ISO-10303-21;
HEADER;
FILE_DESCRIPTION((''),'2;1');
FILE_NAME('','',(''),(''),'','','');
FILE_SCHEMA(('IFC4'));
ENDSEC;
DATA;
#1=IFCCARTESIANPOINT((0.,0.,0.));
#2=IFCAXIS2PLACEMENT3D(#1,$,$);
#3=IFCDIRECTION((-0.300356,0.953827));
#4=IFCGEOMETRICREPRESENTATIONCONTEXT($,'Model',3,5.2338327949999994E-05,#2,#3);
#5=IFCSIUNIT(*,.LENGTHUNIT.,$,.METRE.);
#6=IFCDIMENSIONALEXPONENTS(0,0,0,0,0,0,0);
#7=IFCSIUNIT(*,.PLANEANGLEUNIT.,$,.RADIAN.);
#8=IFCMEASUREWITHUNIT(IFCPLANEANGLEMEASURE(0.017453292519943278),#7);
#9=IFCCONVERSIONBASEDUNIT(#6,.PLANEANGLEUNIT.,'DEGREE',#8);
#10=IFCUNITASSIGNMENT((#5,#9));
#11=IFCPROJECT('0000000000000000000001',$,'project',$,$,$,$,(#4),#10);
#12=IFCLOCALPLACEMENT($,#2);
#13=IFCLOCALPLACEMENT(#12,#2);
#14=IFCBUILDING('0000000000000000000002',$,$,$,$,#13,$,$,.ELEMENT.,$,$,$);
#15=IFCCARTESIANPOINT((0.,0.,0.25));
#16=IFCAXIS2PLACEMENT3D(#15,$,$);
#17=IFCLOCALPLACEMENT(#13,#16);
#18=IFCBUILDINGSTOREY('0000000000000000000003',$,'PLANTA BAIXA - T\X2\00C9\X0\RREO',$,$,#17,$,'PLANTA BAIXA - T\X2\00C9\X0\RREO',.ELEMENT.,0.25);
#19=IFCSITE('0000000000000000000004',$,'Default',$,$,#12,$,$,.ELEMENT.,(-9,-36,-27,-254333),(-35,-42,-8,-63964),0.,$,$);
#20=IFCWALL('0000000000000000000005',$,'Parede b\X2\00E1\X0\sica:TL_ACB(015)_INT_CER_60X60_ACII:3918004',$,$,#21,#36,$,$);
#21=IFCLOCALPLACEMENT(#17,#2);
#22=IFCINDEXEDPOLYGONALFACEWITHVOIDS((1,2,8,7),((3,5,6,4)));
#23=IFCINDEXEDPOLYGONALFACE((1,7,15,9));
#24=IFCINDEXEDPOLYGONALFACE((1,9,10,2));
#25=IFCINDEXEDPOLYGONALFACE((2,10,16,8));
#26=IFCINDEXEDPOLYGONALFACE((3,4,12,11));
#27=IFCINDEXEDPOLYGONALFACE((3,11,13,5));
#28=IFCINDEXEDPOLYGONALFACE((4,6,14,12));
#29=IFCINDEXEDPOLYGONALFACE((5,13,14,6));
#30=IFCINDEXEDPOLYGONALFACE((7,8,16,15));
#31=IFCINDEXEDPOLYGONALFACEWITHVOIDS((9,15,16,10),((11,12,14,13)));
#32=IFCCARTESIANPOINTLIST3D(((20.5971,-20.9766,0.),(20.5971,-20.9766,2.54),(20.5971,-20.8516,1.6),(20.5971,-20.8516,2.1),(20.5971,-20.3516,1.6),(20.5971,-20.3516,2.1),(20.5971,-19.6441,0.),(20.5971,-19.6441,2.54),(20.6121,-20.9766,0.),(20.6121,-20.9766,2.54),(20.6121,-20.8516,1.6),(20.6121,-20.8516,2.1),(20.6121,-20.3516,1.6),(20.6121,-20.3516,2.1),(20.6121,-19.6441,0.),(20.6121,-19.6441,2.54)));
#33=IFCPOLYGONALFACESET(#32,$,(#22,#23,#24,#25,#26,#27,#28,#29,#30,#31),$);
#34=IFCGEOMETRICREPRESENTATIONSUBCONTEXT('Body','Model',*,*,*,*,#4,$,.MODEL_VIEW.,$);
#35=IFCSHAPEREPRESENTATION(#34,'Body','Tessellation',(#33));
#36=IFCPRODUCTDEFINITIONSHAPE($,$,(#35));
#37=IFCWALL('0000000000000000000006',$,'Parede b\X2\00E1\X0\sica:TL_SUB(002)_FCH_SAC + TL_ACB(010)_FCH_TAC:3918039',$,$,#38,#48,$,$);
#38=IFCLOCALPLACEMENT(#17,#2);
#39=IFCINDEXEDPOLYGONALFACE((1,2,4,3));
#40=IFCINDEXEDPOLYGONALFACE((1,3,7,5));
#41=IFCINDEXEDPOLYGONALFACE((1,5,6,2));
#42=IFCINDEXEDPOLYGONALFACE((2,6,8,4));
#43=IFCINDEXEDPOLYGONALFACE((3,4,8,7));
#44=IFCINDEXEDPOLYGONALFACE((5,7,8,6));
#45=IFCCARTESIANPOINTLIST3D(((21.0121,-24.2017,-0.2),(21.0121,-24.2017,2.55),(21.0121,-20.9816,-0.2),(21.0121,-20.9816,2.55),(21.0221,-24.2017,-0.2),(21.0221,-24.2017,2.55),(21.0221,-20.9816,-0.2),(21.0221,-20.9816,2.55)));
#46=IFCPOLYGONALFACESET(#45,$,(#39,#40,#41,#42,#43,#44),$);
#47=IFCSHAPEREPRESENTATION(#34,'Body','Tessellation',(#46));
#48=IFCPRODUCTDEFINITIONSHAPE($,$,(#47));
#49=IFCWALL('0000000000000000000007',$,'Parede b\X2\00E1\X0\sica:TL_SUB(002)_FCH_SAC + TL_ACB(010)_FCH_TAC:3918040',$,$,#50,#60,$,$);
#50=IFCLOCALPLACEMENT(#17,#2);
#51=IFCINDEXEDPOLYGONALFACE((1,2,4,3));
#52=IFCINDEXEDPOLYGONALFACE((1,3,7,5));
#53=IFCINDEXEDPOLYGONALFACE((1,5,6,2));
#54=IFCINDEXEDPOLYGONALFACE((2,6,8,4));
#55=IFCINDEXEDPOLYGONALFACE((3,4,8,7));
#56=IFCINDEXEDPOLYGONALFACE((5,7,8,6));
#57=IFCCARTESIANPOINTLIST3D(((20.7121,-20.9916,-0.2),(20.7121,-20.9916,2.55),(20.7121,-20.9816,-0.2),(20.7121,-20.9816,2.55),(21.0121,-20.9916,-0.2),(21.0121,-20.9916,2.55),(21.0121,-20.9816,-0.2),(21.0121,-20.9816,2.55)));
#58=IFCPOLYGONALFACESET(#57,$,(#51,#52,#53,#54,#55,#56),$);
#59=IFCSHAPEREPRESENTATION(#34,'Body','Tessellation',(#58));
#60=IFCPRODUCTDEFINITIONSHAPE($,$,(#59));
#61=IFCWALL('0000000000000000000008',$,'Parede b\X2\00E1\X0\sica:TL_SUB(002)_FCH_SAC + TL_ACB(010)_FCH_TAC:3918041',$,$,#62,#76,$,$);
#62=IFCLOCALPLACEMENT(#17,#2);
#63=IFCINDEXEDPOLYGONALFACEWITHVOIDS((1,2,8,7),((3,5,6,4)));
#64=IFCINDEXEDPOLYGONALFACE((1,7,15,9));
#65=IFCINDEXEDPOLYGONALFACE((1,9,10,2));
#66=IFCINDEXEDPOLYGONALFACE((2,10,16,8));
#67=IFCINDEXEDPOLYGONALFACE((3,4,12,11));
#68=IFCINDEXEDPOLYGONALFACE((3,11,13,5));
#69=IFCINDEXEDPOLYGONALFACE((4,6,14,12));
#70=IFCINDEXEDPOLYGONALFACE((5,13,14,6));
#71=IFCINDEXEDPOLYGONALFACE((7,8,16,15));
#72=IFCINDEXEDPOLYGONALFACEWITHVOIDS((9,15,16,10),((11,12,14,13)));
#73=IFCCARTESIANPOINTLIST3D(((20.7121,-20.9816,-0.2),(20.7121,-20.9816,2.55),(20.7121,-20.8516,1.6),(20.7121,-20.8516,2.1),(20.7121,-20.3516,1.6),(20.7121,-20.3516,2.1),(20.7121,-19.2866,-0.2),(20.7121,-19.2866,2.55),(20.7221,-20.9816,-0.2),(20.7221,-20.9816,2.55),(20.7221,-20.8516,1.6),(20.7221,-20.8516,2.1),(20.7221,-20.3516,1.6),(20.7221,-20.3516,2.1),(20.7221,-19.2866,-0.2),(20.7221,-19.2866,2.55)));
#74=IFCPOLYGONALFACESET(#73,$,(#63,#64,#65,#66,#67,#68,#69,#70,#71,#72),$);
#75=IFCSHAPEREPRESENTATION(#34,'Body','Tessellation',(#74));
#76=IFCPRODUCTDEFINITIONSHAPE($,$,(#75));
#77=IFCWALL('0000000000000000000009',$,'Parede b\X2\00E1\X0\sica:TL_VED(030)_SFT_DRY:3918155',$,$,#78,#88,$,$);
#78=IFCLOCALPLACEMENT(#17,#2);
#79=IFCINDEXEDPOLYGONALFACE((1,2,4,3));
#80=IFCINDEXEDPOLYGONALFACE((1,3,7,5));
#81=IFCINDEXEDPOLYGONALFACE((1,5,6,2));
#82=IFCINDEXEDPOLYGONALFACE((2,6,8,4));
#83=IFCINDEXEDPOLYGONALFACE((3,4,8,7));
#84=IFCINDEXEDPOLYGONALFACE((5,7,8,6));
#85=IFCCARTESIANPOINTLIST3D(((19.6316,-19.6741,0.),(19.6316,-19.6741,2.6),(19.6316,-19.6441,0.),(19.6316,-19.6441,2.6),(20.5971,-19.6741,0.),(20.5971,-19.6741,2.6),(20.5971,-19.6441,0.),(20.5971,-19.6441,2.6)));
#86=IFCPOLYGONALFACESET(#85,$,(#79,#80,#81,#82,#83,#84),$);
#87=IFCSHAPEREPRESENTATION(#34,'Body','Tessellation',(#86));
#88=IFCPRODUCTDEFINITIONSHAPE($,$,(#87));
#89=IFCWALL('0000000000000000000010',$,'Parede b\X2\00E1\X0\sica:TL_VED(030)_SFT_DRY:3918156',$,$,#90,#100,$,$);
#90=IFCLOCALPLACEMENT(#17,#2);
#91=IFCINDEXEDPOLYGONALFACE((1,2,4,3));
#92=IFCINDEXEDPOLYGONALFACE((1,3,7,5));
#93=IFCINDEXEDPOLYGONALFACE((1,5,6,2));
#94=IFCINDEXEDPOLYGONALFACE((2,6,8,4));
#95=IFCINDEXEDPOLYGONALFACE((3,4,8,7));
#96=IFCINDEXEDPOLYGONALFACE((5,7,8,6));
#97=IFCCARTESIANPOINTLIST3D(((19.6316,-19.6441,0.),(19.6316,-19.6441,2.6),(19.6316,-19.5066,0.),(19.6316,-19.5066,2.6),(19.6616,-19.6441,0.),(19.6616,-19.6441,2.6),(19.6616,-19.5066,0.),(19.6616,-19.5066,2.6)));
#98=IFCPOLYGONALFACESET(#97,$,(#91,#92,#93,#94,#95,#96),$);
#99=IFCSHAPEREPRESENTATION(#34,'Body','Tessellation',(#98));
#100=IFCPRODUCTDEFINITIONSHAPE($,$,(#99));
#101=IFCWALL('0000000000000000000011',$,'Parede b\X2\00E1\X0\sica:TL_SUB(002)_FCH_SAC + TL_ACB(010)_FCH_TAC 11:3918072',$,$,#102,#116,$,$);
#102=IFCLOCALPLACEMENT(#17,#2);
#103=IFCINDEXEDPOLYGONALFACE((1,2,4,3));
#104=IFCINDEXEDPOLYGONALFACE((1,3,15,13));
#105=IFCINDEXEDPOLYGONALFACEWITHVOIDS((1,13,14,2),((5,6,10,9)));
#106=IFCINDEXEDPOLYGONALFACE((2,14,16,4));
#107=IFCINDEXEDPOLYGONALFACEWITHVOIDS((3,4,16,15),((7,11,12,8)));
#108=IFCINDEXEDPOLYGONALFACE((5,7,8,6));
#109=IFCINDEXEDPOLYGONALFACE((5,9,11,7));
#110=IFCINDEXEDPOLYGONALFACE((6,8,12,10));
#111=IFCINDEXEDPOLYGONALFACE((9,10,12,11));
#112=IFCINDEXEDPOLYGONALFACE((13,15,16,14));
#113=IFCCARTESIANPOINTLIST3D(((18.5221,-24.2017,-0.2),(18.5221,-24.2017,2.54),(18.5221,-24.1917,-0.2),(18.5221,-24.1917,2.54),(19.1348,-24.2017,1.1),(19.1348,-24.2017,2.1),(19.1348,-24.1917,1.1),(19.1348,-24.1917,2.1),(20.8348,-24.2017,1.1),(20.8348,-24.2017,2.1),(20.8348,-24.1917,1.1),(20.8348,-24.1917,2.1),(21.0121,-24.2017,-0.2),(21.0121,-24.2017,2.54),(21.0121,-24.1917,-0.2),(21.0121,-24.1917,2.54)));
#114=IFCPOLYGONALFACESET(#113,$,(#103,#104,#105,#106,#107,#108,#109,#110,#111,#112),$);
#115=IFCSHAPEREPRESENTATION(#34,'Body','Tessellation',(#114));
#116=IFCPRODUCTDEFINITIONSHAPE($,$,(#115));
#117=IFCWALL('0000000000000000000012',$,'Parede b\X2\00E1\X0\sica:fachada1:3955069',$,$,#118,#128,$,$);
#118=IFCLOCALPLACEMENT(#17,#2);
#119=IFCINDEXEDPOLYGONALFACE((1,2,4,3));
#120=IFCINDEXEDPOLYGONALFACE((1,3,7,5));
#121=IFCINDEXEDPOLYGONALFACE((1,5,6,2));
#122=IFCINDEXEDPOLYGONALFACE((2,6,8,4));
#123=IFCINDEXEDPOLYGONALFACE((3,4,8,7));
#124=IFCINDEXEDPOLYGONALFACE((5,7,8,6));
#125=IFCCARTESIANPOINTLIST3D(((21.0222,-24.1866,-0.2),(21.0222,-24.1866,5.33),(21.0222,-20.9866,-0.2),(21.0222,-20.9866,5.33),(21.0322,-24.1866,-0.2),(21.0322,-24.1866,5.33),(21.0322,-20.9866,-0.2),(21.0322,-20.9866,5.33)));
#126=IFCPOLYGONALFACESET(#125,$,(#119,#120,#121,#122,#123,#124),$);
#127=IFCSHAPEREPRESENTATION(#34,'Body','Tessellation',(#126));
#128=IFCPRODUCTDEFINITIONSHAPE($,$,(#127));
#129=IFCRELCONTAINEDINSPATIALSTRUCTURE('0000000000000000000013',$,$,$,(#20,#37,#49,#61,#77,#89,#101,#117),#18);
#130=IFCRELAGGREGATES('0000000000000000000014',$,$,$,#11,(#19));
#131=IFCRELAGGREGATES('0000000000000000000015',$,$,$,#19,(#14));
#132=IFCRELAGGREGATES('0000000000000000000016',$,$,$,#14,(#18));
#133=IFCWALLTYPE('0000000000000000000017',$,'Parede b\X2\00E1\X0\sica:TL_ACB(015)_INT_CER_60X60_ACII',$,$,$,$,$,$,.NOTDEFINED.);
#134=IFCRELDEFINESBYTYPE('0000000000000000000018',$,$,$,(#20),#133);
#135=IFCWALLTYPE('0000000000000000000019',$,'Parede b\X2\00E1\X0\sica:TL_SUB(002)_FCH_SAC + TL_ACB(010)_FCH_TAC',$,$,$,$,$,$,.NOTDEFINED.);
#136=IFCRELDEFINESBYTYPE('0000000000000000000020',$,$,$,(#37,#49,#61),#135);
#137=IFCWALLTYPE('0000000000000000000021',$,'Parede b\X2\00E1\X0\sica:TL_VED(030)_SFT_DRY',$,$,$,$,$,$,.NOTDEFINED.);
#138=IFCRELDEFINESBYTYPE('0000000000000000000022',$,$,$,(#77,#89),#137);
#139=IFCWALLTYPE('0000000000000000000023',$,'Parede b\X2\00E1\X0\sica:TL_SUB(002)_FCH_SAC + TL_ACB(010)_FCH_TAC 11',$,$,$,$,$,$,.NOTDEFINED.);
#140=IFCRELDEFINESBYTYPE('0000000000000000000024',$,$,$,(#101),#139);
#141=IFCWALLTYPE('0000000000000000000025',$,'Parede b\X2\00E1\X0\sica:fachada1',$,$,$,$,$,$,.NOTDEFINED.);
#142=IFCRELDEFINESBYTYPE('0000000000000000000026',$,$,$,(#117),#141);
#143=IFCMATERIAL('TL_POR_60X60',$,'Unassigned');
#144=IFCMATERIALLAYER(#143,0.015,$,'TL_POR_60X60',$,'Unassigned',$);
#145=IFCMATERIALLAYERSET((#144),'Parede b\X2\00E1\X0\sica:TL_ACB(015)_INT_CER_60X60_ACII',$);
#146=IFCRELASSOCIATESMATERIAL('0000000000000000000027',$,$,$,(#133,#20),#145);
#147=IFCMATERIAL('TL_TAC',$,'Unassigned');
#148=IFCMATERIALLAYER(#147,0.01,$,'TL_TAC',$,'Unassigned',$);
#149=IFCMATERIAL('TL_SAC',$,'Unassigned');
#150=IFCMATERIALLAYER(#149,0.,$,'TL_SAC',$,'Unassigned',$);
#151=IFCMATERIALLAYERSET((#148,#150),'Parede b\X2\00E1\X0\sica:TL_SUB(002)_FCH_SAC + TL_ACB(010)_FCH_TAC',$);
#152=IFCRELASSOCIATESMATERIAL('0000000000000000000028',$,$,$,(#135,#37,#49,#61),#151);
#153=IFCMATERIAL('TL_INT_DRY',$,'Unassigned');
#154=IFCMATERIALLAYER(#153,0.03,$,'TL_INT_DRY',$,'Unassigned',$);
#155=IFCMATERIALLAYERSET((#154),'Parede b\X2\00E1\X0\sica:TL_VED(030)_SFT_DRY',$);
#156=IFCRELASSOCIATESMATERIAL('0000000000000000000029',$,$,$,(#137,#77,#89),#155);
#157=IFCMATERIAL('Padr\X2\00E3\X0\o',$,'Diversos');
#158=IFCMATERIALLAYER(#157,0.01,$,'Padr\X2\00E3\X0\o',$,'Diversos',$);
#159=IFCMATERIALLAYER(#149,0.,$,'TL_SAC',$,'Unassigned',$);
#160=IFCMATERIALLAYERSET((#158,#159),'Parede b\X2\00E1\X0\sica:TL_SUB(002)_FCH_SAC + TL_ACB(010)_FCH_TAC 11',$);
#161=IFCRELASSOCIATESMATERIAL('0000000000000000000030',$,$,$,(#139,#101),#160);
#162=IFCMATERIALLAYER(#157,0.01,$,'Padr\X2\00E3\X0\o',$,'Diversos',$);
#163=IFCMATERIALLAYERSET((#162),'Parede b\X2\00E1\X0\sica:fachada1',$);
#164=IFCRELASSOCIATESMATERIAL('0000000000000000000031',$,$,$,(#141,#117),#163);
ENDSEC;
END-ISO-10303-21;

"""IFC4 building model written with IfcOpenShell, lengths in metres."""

from ifc_helpers import new_model, entity, si_unit, converted_unit, direction, frame, frame_2d, origin, place, context, subcontext, project, spatial, rectangle, extrude, material, layer, layer_set, layer_usage, type_object, element, save


model = new_model("IFC4")

# Units and contexts
model_context = context("Model", 3, precision=5.2338327949999994e-05, world=origin(), true_north=direction((-0.300356, 0.953827)))
body_context = subcontext(model_context, "Body", "Model", "MODEL_VIEW")
ifc_project = project(units=[si_unit("LENGTHUNIT", "METRE"), converted_unit("PLANEANGLEUNIT", "DEGREE", entity("IfcPlaneAngleMeasure", 0.017453292519943278), si_unit("PLANEANGLEUNIT", "RADIAN"), dimensions=[0, 0, 0, 0, 0, 0, 0])], contexts=[model_context])

# Site, building, storey
site_placement = place(None, origin())
site = spatial("IfcSite", under=ifc_project, at=site_placement, Name="Default", CompositionType="ELEMENT", RefLatitude=(-9, -36, -27, -254333), RefLongitude=(-35, -42, -8, -63964), RefElevation=0.0)
building_placement = place(site_placement, origin())
building = spatial("IfcBuilding", under=site, at=building_placement, CompositionType="ELEMENT")
storey_placement = place(building_placement, frame((0.0, 0.0, 0.25)))
storey = spatial("IfcBuildingStorey", under=building, at=storey_placement, Name="PLANTA BAIXA - TÉRREO", LongName="PLANTA BAIXA - TÉRREO", CompositionType="ELEMENT", Elevation=0.25)

# Shared definitions
ifc_material_1 = material(Name="TL_SAC", Category="Unassigned")

# Shared definitions
ifc_material_2 = material(Name="TL_POR_60X60", Category="Unassigned")
ifc_layer_1 = layer(ifc_material_2, 0.015, Name="TL_POR_60X60", Category="Unassigned")
ifc_layer_set_1 = layer_set([ifc_layer_1], Name="Parede básica:TL_ACB(015)_INT_CER_60X60_ACII")
wall_type_1 = type_object("IfcWallType", Name="Parede básica:TL_ACB(015)_INT_CER_60X60_ACII", PredefinedType="NOTDEFINED", material=ifc_layer_set_1)

# Wall, opening
ifc_layer_usage_1 = layer_usage(ifc_layer_set_1, "AXIS2", "NEGATIVE", 0.0075)
wall_1_placement = place(storey_placement, frame((20.6046, -20.9766, 0.0), z_axis=(0.0, 0.0, 1.0), x_axis=(0.0, 1.0, 0.0)))
wall_1 = element("IfcWall", 1, at=wall_1_placement, inside=storey, type_object=wall_type_1, material=ifc_layer_usage_1, Name="Parede básica:TL_ACB(015)_INT_CER_60X60_ACII:3918004", context=body_context, shape_type="SweptSolid", body=[
    extrude(rectangle(XDim=1.3325, YDim=0.015, at=frame_2d((0.6662, 0.0), x_axis=(-1.0, 0.0))), origin(), (0.0, 0.0, 1.0), 2.54),
])
opening_1_placement = place(wall_1_placement, frame((20.9766, 20.6046, 1.6)))
element("IfcOpeningElement", 2, at=opening_1_placement, cuts=wall_1, PredefinedType="OPENING", context=body_context, shape_type="SweptSolid", body=[
    extrude(rectangle(XDim=0.5, YDim=0.5, at=frame_2d((0.0, 0.0), x_axis=(1.0, 0.0))), frame((-20.6016, -22.2361, 0.25), z_axis=(0.0, 1.0, 0.0), x_axis=(0.0, 0.0, 1.0)), (0.0, 0.0, 1.0), 3.048),
])

# Walls
ifc_material_3 = material(Name="TL_TAC", Category="Unassigned")
ifc_layer_2 = layer(ifc_material_3, 0.01, Name="TL_TAC", Category="Unassigned")
ifc_layer_3 = layer(ifc_material_1, 0.0, Name="TL_SAC", Category="Unassigned")
ifc_layer_set_2 = layer_set([ifc_layer_2, ifc_layer_3], Name="Parede básica:TL_SUB(002)_FCH_SAC + TL_ACB(010)_FCH_TAC")
ifc_layer_usage_2 = layer_usage(ifc_layer_set_2, "AXIS2", "NEGATIVE", 0.005)
wall_type_2 = type_object("IfcWallType", Name="Parede básica:TL_SUB(002)_FCH_SAC + TL_ACB(010)_FCH_TAC", PredefinedType="NOTDEFINED", material=ifc_layer_set_2)
wall_2_placement = place(storey_placement, frame((21.0171, -24.2017, -0.2), z_axis=(0.0, 0.0, 1.0), x_axis=(0.0, 1.0, 0.0)))
element("IfcWall", 3, at=wall_2_placement, inside=storey, type_object=wall_type_2, material=ifc_layer_usage_2, Name="Parede básica:TL_SUB(002)_FCH_SAC + TL_ACB(010)_FCH_TAC:3918039", context=body_context, shape_type="SweptSolid", body=[
    extrude(rectangle(XDim=3.2201, YDim=0.01, at=frame_2d((1.6101, 0.0), x_axis=(-1.0, 0.0))), origin(), (0.0, 0.0, 1.0), 2.75),
])
ifc_layer_usage_3 = layer_usage(ifc_layer_set_2, "AXIS2", "NEGATIVE", 0.005)
wall_3_placement = place(storey_placement, frame((21.0121, -20.9866, -0.2), z_axis=(0.0, 0.0, 1.0), x_axis=(-1.0, 0.0, 0.0)))
element("IfcWall", 4, at=wall_3_placement, inside=storey, type_object=wall_type_2, material=ifc_layer_usage_3, Name="Parede básica:TL_SUB(002)_FCH_SAC + TL_ACB(010)_FCH_TAC:3918040", context=body_context, shape_type="SweptSolid", body=[
    extrude(rectangle(XDim=0.3, YDim=0.01, at=frame_2d((0.15, 0.0), x_axis=(-1.0, 0.0))), origin(), (0.0, 0.0, 1.0), 2.75),
])

# Wall, opening
ifc_layer_usage_4 = layer_usage(ifc_layer_set_2, "AXIS2", "NEGATIVE", 0.005)
wall_4_placement = place(storey_placement, frame((20.7171, -20.9816, -0.2), z_axis=(0.0, 0.0, 1.0), x_axis=(0.0, 1.0, 0.0)))
wall_4 = element("IfcWall", 5, at=wall_4_placement, inside=storey, type_object=wall_type_2, material=ifc_layer_usage_4, Name="Parede básica:TL_SUB(002)_FCH_SAC + TL_ACB(010)_FCH_TAC:3918041", context=body_context, shape_type="SweptSolid", body=[
    extrude(rectangle(XDim=1.695, YDim=0.01, at=frame_2d((0.8475, 0.0), x_axis=(-1.0, 0.0))), origin(), (0.0, 0.0, 1.0), 2.75),
])
opening_2_placement = place(wall_4_placement, frame((20.9816, 20.7171, 1.8)))
element("IfcOpeningElement", 6, at=opening_2_placement, cuts=wall_4, PredefinedType="OPENING", context=body_context, shape_type="SweptSolid", body=[
    extrude(rectangle(XDim=0.5, YDim=0.5, at=frame_2d((0.0, 0.0), x_axis=(1.0, 0.0))), frame((-20.6016, -22.2361, 0.25), z_axis=(0.0, 1.0, 0.0), x_axis=(0.0, 0.0, 1.0)), (0.0, 0.0, 1.0), 3.048),
])

# Walls
ifc_material_4 = material(Name="TL_INT_DRY", Category="Unassigned")
ifc_layer_4 = layer(ifc_material_4, 0.03, Name="TL_INT_DRY", Category="Unassigned")
ifc_layer_set_3 = layer_set([ifc_layer_4], Name="Parede básica:TL_VED(030)_SFT_DRY")
ifc_layer_usage_5 = layer_usage(ifc_layer_set_3, "AXIS2", "NEGATIVE", 0.015)
wall_type_3 = type_object("IfcWallType", Name="Parede básica:TL_VED(030)_SFT_DRY", PredefinedType="NOTDEFINED", material=ifc_layer_set_3)
wall_5_placement = place(storey_placement, frame((20.5971, -19.6591, 0.0), z_axis=(0.0, 0.0, 1.0), x_axis=(-1.0, 0.0, 0.0)))
element("IfcWall", 7, at=wall_5_placement, inside=storey, type_object=wall_type_3, material=ifc_layer_usage_5, Name="Parede básica:TL_VED(030)_SFT_DRY:3918155", context=body_context, shape_type="SweptSolid", body=[
    extrude(rectangle(XDim=0.9655, YDim=0.03, at=frame_2d((0.4828, 0.0), x_axis=(-1.0, 0.0))), origin(), (0.0, 0.0, 1.0), 2.6),
])
ifc_layer_usage_6 = layer_usage(ifc_layer_set_3, "AXIS2", "NEGATIVE", 0.015)
wall_6_placement = place(storey_placement, frame((19.6466, -19.6441, 0.0), z_axis=(0.0, 0.0, 1.0), x_axis=(0.0, 1.0, 0.0)))
element("IfcWall", 8, at=wall_6_placement, inside=storey, type_object=wall_type_3, material=ifc_layer_usage_6, Name="Parede básica:TL_VED(030)_SFT_DRY:3918156", context=body_context, shape_type="SweptSolid", body=[
    extrude(rectangle(XDim=0.1375, YDim=0.03, at=frame_2d((0.0688, 0.0), x_axis=(-1.0, 0.0))), origin(), (0.0, 0.0, 1.0), 2.6),
])

# Wall, opening
ifc_material_5 = material(Name="Padrão", Category="Diversos")
ifc_layer_5 = layer(ifc_material_5, 0.01, Name="Padrão", Category="Diversos")
ifc_layer_6 = layer(ifc_material_1, 0.0, Name="TL_SAC", Category="Unassigned")
ifc_layer_set_4 = layer_set([ifc_layer_5, ifc_layer_6], Name="Parede básica:TL_SUB(002)_FCH_SAC + TL_ACB(010)_FCH_TAC 11")
ifc_layer_usage_7 = layer_usage(ifc_layer_set_4, "AXIS2", "NEGATIVE", 0.005)
wall_type_4 = type_object("IfcWallType", Name="Parede básica:TL_SUB(002)_FCH_SAC + TL_ACB(010)_FCH_TAC 11", PredefinedType="NOTDEFINED", material=ifc_layer_set_4)
wall_7_placement = place(storey_placement, frame((18.5221, -24.1967, -0.2)))
wall_7 = element("IfcWall", 9, at=wall_7_placement, inside=storey, type_object=wall_type_4, material=ifc_layer_usage_7, Name="Parede básica:TL_SUB(002)_FCH_SAC + TL_ACB(010)_FCH_TAC 11:3918072", context=body_context, shape_type="SweptSolid", body=[
    extrude(rectangle(XDim=2.49, YDim=0.01, at=frame_2d((1.245, 0.0), x_axis=(-1.0, 0.0))), origin(), (0.0, 0.0, 1.0), 2.74),
])
opening_3_placement = place(wall_7_placement, frame((-18.5221, 24.1967, 1.3)))
element("IfcOpeningElement", 10, at=opening_3_placement, cuts=wall_7, PredefinedType="OPENING", context=body_context, shape_type="SweptSolid", body=[
    extrude(rectangle(XDim=1.0, YDim=1.7, at=frame_2d((0.0, 0.0), x_axis=(0.0, 1.0))), frame((19.9848, -25.6157, 0.5), z_axis=(0.0, 1.0, 0.0), x_axis=(1.0, 0.0, 0.0)), (0.0, 0.0, 1.0), 3.048),
])

# Wall
ifc_layer_7 = layer(ifc_material_5, 0.01, Name="Padrão", Category="Diversos")
ifc_layer_set_5 = layer_set([ifc_layer_7], Name="Parede básica:fachada1")
ifc_layer_usage_8 = layer_usage(ifc_layer_set_5, "AXIS2", "POSITIVE", -0.005)
wall_type_5 = type_object("IfcWallType", Name="Parede básica:fachada1", PredefinedType="NOTDEFINED", material=ifc_layer_set_5)
wall_8_placement = place(storey_placement, frame((21.0272, -20.9866, -0.2), z_axis=(0.0, 0.0, 1.0), x_axis=(0.0, -1.0, 0.0)))
element("IfcWall", 11, at=wall_8_placement, inside=storey, type_object=wall_type_5, material=ifc_layer_usage_8, Name="Parede básica:fachada1:3955069", context=body_context, shape_type="SweptSolid", body=[
    extrude(rectangle(XDim=3.2, YDim=0.01, at=frame_2d((1.6, 0.0), x_axis=(-1.0, 0.0))), origin(), (0.0, 0.0, 1.0), 5.53),
])

save(model, "model.ifc")
